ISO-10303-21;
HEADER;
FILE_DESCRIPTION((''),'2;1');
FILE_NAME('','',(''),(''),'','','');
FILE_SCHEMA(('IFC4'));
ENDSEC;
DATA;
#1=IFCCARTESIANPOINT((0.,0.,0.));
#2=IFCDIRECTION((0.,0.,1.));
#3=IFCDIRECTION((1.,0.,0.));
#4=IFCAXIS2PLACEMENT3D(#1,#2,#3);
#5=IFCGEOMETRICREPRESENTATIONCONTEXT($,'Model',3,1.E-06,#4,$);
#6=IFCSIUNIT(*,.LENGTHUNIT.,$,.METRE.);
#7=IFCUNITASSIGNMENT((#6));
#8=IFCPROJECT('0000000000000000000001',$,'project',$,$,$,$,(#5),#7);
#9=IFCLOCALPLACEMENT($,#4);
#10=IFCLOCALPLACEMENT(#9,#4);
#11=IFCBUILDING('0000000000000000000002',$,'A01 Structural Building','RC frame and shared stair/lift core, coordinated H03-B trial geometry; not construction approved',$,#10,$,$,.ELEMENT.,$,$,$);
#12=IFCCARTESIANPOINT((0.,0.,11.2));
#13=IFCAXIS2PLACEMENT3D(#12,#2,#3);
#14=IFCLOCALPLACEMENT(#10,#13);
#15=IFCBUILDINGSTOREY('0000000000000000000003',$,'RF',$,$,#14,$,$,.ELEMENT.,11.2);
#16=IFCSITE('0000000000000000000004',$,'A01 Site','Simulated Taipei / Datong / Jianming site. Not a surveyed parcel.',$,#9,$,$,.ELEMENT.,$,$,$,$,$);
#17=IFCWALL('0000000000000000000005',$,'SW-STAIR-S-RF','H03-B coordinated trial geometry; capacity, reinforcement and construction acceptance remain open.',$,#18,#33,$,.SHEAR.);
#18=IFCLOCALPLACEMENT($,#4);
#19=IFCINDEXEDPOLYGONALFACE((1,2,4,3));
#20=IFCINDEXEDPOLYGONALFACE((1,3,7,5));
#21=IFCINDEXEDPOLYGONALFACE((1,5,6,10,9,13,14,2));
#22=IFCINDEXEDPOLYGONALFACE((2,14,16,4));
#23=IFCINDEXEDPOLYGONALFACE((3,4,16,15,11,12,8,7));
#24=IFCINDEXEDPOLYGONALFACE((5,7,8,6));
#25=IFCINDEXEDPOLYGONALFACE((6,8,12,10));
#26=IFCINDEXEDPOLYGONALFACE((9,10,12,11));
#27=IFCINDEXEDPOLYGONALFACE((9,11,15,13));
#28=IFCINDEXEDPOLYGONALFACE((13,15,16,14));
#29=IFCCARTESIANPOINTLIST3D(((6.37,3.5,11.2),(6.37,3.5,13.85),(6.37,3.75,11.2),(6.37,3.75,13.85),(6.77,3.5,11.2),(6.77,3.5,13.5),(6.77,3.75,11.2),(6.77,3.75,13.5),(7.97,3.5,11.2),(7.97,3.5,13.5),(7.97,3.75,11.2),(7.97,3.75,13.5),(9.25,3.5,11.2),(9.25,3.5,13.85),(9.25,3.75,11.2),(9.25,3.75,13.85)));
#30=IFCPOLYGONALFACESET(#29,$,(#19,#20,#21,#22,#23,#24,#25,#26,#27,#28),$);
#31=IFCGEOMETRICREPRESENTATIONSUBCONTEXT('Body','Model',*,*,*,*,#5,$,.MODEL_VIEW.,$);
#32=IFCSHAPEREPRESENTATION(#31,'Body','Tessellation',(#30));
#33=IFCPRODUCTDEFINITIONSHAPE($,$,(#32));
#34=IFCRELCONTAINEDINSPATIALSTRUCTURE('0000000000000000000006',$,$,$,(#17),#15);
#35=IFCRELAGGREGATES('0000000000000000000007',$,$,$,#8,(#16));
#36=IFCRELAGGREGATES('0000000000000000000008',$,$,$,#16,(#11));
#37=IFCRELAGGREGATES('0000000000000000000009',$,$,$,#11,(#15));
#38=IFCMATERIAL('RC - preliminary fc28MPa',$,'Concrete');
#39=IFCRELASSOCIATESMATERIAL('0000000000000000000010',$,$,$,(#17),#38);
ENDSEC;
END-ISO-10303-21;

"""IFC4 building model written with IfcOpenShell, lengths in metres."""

from ifc_helpers import new_model, si_unit, frame, origin_with_axes, place, context, subcontext, project, spatial, polyline, outline, extrude, material, element, save


model = new_model("IFC4")

# Units and contexts
model_context = context("Model", 3, precision=1e-06, world=origin_with_axes())
body_context = subcontext(model_context, "Body", "Model", "MODEL_VIEW")
ifc_project = project(units=[si_unit("LENGTHUNIT", "METRE")], contexts=[model_context])

# Site, building, storey
site_placement = place(None, origin_with_axes())
site = spatial("IfcSite", under=ifc_project, at=site_placement, Name="A01 Site", Description="Simulated Taipei / Datong / Jianming site. Not a surveyed parcel.", CompositionType="ELEMENT")
building_placement = place(site_placement, origin_with_axes())
building = spatial("IfcBuilding", under=site, at=building_placement, Name="A01 Structural Building", Description="RC frame and shared stair/lift core, coordinated H03-B trial geometry; not construction approved", CompositionType="ELEMENT")
storey_placement = place(building_placement, frame((0.0, 0.0, 11.2), z_axis=(0.0, 0.0, 1.0), x_axis=(1.0, 0.0, 0.0)))
storey = spatial("IfcBuildingStorey", under=building, at=storey_placement, Name="RF", CompositionType="ELEMENT", Elevation=11.2)

# Shared definitions
ifc_material = material(Name="RC - preliminary fc28MPa", Category="Concrete")

# Shared definitions
placement = place(None, origin_with_axes())

# Wall, opening
wall_1 = element("IfcWall", 1, at=placement, inside=storey, material=ifc_material, Name="SW-STAIR-S-RF", Description="H03-B coordinated trial geometry; capacity, reinforcement and construction acceptance remain open.", PredefinedType="SHEAR", context=body_context, shape_type="SweptSolid", body=[
    extrude(outline(polyline([(9.25, 3.5), (9.25, 3.75), (6.37, 3.75), (6.37, 3.5), (9.25, 3.5)])), frame((0.0, 0.0, 11.2), z_axis=(0.0, 0.0, 1.0), x_axis=(1.0, 0.0, 0.0)), (0.0, 0.0, 1.0), 2.65),
])
element("IfcOpeningElement", 2, at=placement, cuts=wall_1, PredefinedType="OPENING", context=body_context, shape_type="SweptSolid", body=[
    extrude(outline(polyline([(7.97, 3.45), (7.97, 3.8), (6.77, 3.8), (6.77, 3.45), (7.97, 3.45)])), frame((0.0, 0.0, 11.2), z_axis=(0.0, 0.0, 1.0), x_axis=(1.0, 0.0, 0.0)), (0.0, 0.0, 1.0), 2.3),
])

save(model, "model.ifc")
